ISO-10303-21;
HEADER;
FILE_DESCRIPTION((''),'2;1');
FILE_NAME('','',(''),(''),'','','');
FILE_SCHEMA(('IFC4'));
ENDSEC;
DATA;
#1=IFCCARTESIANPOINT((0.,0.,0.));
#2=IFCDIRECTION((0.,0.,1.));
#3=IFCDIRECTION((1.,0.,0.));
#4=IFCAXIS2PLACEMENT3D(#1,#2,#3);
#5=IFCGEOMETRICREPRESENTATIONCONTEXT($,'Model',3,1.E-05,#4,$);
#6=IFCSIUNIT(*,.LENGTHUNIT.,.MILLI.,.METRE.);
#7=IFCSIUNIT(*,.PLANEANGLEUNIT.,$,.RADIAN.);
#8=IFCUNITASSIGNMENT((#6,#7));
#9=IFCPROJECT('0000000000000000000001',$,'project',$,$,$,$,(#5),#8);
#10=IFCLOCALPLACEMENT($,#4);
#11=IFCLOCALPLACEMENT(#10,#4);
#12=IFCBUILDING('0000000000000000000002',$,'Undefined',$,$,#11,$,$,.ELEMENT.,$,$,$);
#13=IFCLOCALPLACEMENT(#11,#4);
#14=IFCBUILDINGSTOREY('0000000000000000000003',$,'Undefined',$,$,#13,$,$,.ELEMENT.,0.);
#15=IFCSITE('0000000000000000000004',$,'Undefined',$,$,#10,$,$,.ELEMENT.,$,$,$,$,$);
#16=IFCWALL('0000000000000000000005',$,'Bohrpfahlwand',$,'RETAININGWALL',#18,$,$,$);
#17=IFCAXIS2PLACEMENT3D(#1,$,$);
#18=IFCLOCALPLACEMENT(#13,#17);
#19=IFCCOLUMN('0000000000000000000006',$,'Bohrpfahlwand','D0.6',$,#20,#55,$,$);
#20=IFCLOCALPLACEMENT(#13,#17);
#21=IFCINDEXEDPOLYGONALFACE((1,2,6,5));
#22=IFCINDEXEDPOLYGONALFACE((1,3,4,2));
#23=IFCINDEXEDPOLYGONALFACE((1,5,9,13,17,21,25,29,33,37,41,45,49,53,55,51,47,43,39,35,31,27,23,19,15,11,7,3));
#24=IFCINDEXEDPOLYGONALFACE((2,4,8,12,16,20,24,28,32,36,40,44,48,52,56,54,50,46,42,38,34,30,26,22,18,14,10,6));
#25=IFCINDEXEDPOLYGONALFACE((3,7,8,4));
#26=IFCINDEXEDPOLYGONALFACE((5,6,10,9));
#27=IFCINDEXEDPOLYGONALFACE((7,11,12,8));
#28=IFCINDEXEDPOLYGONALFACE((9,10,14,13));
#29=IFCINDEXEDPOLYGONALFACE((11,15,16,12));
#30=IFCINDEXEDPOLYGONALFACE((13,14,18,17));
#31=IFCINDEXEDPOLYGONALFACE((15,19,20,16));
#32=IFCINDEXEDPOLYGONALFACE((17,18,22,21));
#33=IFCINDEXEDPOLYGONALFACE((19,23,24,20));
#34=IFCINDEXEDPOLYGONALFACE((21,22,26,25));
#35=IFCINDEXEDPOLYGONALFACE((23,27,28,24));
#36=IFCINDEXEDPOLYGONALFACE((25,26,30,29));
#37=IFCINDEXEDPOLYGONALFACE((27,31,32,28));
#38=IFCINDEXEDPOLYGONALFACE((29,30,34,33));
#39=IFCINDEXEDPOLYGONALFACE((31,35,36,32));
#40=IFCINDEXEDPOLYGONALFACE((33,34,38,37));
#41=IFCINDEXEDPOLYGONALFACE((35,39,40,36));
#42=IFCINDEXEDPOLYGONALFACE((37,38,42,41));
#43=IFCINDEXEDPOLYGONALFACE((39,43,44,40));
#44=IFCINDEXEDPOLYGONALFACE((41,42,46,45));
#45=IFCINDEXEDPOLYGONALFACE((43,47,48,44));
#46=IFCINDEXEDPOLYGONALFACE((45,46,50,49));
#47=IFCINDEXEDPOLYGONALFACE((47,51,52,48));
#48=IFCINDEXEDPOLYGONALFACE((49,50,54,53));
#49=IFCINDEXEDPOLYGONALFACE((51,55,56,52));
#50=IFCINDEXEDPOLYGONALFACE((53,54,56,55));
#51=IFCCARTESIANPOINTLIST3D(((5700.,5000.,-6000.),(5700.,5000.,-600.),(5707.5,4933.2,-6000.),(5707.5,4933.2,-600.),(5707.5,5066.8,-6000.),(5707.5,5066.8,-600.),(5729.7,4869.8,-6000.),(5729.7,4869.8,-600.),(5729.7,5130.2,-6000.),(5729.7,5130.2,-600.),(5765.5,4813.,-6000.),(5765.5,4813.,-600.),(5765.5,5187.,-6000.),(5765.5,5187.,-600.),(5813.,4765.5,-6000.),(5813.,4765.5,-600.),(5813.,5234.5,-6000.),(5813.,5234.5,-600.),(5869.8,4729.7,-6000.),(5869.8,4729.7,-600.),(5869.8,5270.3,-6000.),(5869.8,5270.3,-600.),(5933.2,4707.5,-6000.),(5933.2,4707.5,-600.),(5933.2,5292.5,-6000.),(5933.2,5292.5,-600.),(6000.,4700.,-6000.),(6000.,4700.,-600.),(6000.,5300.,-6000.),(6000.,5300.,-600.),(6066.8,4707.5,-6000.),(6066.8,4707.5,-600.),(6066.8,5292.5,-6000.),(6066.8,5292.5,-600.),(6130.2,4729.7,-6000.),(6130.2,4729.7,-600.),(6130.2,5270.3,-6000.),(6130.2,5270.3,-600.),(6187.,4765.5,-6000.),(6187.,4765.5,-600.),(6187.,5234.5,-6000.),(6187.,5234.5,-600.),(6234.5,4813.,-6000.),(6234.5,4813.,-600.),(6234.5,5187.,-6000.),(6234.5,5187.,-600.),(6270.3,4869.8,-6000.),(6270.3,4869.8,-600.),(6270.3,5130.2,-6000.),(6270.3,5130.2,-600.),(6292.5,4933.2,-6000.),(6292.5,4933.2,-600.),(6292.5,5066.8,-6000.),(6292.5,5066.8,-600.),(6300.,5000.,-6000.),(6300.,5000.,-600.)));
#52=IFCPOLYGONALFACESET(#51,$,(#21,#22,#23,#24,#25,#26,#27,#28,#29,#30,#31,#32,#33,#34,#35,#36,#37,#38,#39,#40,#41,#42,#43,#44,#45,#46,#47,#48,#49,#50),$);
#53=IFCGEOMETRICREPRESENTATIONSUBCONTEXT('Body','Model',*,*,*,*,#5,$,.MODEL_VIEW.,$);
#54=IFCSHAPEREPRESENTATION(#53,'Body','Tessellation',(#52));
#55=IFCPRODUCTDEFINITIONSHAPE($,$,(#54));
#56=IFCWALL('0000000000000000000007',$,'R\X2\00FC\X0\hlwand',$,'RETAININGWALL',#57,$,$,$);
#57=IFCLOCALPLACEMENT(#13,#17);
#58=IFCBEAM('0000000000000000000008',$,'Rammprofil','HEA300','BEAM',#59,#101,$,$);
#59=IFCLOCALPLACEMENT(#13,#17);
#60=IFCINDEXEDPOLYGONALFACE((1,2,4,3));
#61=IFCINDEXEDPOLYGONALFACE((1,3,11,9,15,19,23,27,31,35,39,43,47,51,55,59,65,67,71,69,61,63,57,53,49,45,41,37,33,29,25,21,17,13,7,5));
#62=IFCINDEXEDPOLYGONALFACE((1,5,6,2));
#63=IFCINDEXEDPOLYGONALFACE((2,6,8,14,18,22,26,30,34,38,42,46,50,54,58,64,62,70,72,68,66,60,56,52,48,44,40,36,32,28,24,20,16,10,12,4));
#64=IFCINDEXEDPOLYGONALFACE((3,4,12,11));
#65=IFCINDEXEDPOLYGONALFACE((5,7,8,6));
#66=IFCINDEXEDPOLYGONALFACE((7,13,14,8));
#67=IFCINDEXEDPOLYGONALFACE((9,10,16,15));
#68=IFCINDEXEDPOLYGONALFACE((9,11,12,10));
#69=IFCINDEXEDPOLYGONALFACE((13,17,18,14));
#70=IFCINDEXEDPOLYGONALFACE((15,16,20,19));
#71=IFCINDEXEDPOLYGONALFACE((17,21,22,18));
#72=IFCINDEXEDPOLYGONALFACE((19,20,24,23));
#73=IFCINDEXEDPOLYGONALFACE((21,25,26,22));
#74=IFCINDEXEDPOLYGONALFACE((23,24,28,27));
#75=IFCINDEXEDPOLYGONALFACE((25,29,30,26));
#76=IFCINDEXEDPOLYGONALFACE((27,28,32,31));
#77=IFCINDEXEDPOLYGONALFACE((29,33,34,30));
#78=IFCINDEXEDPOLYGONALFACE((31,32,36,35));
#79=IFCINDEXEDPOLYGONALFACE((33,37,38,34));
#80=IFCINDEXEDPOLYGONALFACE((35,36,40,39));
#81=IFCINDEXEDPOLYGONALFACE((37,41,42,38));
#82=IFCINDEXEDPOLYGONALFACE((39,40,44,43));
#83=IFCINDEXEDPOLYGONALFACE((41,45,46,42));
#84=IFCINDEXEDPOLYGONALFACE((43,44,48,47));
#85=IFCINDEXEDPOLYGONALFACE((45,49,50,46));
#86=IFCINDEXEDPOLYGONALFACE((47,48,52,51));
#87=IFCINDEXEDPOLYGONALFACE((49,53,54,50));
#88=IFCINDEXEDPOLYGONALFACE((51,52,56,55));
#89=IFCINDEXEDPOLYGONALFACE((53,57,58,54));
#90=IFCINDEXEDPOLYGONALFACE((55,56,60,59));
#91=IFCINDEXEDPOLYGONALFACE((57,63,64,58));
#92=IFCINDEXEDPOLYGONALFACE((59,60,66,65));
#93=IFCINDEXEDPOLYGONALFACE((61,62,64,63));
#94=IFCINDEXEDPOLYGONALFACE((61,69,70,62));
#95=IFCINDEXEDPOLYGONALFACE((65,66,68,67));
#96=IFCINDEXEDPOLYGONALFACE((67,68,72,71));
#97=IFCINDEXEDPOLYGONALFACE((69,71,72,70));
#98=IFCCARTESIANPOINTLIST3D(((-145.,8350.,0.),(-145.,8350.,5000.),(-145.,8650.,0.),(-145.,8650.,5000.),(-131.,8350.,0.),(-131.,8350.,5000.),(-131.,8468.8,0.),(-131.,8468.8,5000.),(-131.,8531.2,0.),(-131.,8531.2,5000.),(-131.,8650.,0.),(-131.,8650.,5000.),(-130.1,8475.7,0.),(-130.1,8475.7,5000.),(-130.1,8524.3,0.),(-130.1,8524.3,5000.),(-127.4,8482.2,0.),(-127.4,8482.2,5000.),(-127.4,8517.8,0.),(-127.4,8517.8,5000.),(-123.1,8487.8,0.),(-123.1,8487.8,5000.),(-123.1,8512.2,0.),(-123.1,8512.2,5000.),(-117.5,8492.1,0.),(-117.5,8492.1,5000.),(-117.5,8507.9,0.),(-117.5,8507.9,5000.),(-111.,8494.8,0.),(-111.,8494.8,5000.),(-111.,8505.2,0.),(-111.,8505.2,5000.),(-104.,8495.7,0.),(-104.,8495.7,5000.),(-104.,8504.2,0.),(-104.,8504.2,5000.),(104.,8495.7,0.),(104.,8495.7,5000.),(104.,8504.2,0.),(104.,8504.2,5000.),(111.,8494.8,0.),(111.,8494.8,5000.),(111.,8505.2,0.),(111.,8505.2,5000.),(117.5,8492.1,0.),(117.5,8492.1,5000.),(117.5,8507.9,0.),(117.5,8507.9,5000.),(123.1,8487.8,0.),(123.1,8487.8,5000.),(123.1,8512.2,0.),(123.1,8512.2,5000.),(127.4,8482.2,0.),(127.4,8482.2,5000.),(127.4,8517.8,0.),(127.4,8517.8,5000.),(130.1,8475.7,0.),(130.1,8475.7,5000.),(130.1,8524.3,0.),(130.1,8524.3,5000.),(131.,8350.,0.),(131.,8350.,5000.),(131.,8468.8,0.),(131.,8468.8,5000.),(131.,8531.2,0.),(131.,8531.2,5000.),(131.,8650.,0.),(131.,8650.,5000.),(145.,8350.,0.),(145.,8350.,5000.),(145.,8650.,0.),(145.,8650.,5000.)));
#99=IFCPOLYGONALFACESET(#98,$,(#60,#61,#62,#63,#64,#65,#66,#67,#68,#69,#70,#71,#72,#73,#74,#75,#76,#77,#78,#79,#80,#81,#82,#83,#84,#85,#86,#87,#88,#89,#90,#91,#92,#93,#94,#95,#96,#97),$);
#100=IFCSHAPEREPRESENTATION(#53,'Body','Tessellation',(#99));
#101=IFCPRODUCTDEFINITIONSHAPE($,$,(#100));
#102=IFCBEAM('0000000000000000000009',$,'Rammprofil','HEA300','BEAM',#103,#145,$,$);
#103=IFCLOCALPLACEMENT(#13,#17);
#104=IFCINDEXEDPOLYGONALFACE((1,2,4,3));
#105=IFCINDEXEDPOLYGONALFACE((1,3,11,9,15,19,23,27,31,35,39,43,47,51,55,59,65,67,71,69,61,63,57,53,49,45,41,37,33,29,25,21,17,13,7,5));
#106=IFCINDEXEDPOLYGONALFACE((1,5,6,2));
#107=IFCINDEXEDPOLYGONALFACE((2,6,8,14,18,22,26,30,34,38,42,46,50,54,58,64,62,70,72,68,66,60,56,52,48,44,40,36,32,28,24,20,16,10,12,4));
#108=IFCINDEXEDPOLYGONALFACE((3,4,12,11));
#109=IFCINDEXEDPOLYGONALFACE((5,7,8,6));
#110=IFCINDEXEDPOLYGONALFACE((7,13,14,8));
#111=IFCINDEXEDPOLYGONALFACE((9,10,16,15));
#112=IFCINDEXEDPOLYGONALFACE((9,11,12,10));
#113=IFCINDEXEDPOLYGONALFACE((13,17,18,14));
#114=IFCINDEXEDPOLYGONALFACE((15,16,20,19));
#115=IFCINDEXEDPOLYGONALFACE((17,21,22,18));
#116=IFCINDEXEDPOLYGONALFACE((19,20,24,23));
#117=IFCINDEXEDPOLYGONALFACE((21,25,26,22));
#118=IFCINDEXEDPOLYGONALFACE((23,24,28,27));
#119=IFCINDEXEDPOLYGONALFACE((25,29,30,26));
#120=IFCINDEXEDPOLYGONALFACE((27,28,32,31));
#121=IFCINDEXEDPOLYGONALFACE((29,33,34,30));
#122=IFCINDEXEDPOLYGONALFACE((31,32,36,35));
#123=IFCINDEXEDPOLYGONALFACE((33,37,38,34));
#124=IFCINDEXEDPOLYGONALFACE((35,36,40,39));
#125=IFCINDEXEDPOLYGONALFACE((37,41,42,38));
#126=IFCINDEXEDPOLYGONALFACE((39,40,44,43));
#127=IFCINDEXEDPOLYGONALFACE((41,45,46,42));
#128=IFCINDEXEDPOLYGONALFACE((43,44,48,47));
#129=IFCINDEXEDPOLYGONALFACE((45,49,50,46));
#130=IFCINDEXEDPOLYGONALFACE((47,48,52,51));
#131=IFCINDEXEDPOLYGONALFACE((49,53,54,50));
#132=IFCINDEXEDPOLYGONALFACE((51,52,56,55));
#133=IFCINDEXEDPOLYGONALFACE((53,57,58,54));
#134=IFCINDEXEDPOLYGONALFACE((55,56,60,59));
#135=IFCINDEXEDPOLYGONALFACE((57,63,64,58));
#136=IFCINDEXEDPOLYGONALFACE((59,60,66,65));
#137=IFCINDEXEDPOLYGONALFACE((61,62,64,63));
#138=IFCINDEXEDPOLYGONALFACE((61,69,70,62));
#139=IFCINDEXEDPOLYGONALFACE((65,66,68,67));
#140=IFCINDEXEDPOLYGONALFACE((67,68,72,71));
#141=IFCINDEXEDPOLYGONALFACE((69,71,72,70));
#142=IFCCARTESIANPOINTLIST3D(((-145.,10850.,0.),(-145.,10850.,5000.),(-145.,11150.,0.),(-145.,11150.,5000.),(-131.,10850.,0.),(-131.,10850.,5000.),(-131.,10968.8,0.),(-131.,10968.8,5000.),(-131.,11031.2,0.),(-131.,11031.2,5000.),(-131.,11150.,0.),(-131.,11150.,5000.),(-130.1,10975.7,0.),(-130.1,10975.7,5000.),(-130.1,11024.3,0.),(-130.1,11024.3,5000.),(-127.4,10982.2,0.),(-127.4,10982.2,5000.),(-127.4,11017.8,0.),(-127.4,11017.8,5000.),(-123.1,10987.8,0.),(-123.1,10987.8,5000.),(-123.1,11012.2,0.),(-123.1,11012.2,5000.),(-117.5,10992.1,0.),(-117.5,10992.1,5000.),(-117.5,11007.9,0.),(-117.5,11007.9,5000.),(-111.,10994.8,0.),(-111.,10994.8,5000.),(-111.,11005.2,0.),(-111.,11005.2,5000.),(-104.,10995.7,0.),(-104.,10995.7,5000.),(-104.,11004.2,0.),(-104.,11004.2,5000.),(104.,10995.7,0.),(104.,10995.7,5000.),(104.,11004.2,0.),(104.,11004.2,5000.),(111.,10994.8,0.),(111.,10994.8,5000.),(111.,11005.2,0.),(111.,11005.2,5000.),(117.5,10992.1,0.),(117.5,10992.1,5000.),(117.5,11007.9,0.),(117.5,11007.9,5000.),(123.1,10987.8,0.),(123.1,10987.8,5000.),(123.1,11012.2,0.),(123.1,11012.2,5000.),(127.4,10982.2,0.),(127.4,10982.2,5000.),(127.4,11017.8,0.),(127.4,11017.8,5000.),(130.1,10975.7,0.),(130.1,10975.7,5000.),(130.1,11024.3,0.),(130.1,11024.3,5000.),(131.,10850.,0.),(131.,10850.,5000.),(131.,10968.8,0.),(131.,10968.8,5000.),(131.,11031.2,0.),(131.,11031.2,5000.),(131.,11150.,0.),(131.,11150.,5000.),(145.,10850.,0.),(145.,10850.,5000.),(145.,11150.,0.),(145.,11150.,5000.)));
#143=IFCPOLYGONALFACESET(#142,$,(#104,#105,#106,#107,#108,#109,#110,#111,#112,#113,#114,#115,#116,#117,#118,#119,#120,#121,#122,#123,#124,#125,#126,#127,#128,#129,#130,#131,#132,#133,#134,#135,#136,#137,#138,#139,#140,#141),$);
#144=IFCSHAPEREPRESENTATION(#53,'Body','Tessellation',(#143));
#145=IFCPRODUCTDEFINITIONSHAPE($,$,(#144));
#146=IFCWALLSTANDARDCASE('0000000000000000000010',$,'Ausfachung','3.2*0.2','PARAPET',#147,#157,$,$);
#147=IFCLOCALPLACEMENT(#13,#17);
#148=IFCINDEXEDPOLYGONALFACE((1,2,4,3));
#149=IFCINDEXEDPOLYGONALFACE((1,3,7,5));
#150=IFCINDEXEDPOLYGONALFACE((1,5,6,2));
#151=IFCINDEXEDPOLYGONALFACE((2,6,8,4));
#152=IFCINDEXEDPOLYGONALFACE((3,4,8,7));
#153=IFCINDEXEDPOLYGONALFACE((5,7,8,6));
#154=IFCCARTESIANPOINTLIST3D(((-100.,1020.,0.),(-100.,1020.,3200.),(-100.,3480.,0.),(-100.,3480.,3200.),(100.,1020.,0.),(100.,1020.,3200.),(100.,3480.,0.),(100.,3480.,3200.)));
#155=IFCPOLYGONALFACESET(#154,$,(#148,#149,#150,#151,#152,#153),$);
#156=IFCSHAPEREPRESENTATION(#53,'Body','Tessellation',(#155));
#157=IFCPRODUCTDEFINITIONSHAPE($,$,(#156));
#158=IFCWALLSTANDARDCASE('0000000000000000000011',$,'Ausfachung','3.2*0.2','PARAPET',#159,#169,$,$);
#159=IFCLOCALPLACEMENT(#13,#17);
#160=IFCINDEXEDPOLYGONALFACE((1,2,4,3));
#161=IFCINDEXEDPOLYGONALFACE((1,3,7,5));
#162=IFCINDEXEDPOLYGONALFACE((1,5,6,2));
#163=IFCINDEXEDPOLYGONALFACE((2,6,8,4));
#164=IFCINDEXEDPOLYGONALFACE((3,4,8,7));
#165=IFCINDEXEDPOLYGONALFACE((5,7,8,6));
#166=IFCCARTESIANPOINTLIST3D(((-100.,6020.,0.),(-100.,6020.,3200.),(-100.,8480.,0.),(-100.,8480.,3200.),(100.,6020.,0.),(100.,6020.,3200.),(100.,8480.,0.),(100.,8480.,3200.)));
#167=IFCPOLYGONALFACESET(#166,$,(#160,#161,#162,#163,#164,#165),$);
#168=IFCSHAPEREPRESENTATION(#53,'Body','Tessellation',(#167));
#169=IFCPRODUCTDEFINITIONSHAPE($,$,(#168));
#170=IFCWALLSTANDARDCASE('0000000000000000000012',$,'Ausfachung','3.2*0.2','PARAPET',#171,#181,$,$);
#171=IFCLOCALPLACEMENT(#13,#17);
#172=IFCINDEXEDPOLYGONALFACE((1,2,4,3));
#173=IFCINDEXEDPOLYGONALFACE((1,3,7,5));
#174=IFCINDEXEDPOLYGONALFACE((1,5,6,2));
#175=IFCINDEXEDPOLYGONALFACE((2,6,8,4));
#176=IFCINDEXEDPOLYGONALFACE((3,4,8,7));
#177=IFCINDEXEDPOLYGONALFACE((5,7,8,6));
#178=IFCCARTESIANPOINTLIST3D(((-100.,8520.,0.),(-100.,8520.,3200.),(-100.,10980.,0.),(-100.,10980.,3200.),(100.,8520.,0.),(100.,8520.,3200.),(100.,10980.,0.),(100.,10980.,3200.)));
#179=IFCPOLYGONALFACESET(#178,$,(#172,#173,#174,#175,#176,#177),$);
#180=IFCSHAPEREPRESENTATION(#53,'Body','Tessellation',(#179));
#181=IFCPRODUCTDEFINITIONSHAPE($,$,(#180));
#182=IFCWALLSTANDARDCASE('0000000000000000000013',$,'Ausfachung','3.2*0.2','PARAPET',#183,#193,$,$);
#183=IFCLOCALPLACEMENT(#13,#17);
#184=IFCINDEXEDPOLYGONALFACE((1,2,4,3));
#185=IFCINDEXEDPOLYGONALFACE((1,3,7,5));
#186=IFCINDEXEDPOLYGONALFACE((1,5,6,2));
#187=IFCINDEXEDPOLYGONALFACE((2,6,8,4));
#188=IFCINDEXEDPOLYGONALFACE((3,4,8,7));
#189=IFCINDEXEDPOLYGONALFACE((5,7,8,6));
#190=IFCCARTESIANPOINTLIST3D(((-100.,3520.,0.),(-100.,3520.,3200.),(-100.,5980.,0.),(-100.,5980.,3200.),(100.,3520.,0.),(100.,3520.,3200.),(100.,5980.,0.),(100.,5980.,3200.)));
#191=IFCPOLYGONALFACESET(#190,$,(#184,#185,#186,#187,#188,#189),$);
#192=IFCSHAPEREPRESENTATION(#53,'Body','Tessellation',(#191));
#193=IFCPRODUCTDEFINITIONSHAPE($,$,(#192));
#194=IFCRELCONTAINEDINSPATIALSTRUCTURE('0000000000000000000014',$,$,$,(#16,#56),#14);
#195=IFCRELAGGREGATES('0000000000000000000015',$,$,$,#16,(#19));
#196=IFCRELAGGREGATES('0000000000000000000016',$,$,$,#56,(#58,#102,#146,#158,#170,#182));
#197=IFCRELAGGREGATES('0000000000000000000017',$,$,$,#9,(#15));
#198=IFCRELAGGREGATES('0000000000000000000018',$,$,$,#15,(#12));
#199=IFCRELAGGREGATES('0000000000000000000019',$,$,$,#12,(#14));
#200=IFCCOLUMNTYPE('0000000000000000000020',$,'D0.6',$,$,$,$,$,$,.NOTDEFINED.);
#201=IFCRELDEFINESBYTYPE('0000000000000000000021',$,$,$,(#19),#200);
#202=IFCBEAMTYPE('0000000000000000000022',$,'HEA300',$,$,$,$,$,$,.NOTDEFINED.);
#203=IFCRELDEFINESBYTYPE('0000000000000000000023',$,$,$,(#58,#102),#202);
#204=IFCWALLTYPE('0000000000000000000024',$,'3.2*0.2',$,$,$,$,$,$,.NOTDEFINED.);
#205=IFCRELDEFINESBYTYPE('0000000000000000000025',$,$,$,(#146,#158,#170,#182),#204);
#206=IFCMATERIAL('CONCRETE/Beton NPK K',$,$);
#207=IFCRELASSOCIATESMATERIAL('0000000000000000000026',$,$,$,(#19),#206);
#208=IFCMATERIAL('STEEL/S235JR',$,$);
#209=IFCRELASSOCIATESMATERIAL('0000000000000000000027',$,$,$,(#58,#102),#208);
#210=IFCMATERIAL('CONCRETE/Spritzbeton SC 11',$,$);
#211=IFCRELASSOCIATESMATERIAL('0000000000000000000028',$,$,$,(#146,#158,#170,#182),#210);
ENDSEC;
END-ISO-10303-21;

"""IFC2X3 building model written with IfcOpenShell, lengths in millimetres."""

from ifc_helpers import new_model, si_unit, frame, frame_2d, origin_with_axes, origin_2d_with_axis, place, context, subcontext, project, spatial, rectangle, circle, i_section, extrude, material, type_object, element, aggregate, save


model = new_model("IFC2X3")

# Units and contexts
model_context = context("Model", 3, precision=1e-05, world=origin_with_axes())
body_context = subcontext(model_context, "Body", "Model", "MODEL_VIEW")
ifc_project = project(units=[si_unit("LENGTHUNIT", "METRE", prefix="MILLI"), si_unit("PLANEANGLEUNIT", "RADIAN")], contexts=[model_context])

# Site, building, storey
site_placement = place(None, origin_with_axes())
site = spatial("IfcSite", under=ifc_project, at=site_placement, Name="Undefined", CompositionType="ELEMENT")
building_placement = place(site_placement, origin_with_axes())
building = spatial("IfcBuilding", under=site, at=building_placement, Name="Undefined", CompositionType="ELEMENT")
storey_placement = place(building_placement, origin_with_axes())
storey = spatial("IfcBuildingStorey", under=building, at=storey_placement, Name="Undefined", CompositionType="ELEMENT", Elevation=0.0)

# Shared definitions
ifc_material_1 = material(Name="CONCRETE/Beton NPK K")

# Wall, column
wall_1_placement = place(storey_placement, origin_with_axes())
wall_1 = element("IfcWall", 1, at=wall_1_placement, inside=storey, Name="Bohrpfahlwand", ObjectType="RETAININGWALL")
column_type = type_object("IfcColumnType", Name="D0.6", PredefinedType="NOTDEFINED")
column_1_placement = place(wall_1_placement, frame((6000.0, 5000.0, -6000.0), z_axis=(0.0, 0.0, 1.0), x_axis=(0.0, 1.0, 0.0)))
column_1 = element("IfcColumn", 2, at=column_1_placement, type_object=column_type, material=ifc_material_1, Name="Bohrpfahlwand", Description="D0.6", context=body_context, shape_type="SweptSolid", body=[
    extrude(circle(Radius=300.0, at=origin_2d_with_axis()), frame((0.0, 0.0, 5400.0), z_axis=(0.0, 0.0, -1.0), x_axis=(0.0, 1.0, 0.0)), (0.0, 0.0, 1.0), 5400.0),
])
aggregate(wall_1, [column_1])

# Walls, beams
wall_2_placement = place(storey_placement, origin_with_axes())
wall_2 = element("IfcWall", 3, at=wall_2_placement, inside=storey, Name="Rühlwand", ObjectType="RETAININGWALL")
ifc_material_2 = material(Name="STEEL/S235JR")
beam_type = type_object("IfcBeamType", Name="HEA300", PredefinedType="NOTDEFINED")
beam_1_placement = place(wall_2_placement, frame((0.0, 8500.0, 0.0), z_axis=(-1.0, 0.0, 0.0), x_axis=(0.0, 0.0, 1.0)))
beam_1 = element("IfcBeam", 4, at=beam_1_placement, type_object=beam_type, material=ifc_material_2, Name="Rammprofil", Description="HEA300", ObjectType="BEAM", context=body_context, shape_type="SweptSolid", body=[
    extrude(i_section(OverallWidth=300.0, OverallDepth=290.0, WebThickness=8.5, FlangeThickness=14.0, FilletRadius=27.0, at=origin_2d_with_axis()), frame((5000.0, 0.0, 0.0), z_axis=(-1.0, 0.0, 0.0), x_axis=(0.0, -1.0, 0.0)), (0.0, 0.0, 1.0), 5000.0),
])
beam_2_placement = place(wall_2_placement, frame((0.0, 11000.0, 0.0), z_axis=(-1.0, 0.0, 0.0), x_axis=(0.0, 0.0, 1.0)))
beam_2 = element("IfcBeam", 5, at=beam_2_placement, type_object=beam_type, material=ifc_material_2, Name="Rammprofil", Description="HEA300", ObjectType="BEAM", context=body_context, shape_type="SweptSolid", body=[
    extrude(i_section(OverallWidth=300.0, OverallDepth=290.0, WebThickness=8.5, FlangeThickness=14.0, FilletRadius=27.0, at=origin_2d_with_axis()), frame((5000.0, 0.0, 0.0), z_axis=(-1.0, 0.0, 0.0), x_axis=(0.0, -1.0, 0.0)), (0.0, 0.0, 1.0), 5000.0),
])
ifc_material_3 = material(Name="CONCRETE/Spritzbeton SC 11")
wall_type = type_object("IfcWallType", Name="3.2*0.2", PredefinedType="NOTDEFINED")
wall_3_placement = place(wall_2_placement, frame((0.0, 3480.0, 0.0), z_axis=(0.0, 0.0, 1.0), x_axis=(0.0, -1.0, 0.0)))
wall_3 = element("IfcWallStandardCase", 6, at=wall_3_placement, type_object=wall_type, material=ifc_material_3, Name="Ausfachung", Description="3.2*0.2", ObjectType="PARAPET", context=body_context, shape_type="SweptSolid", body=[
    extrude(rectangle(XDim=2460.0, YDim=200.0, at=frame_2d((0.0, 1230.0), x_axis=(0.0, -1.0))), frame((0.0, 0.0, 0.0), z_axis=(0.0, 0.0, 1.0), x_axis=(0.0, -1.0, 0.0)), (0.0, 0.0, 1.0), 3200.0),
])
wall_4_placement = place(wall_2_placement, frame((0.0, 8480.0, 0.0), z_axis=(0.0, 0.0, 1.0), x_axis=(0.0, -1.0, 0.0)))
wall_4 = element("IfcWallStandardCase", 7, at=wall_4_placement, type_object=wall_type, material=ifc_material_3, Name="Ausfachung", Description="3.2*0.2", ObjectType="PARAPET", context=body_context, shape_type="SweptSolid", body=[
    extrude(rectangle(XDim=2460.0, YDim=200.0, at=frame_2d((0.0, 1230.0), x_axis=(0.0, -1.0))), frame((0.0, 0.0, 0.0), z_axis=(0.0, 0.0, 1.0), x_axis=(0.0, -1.0, 0.0)), (0.0, 0.0, 1.0), 3200.0),
])
wall_5_placement = place(wall_2_placement, frame((0.0, 10980.0, 0.0), z_axis=(0.0, 0.0, 1.0), x_axis=(0.0, -1.0, 0.0)))
wall_5 = element("IfcWallStandardCase", 8, at=wall_5_placement, type_object=wall_type, material=ifc_material_3, Name="Ausfachung", Description="3.2*0.2", ObjectType="PARAPET", context=body_context, shape_type="SweptSolid", body=[
    extrude(rectangle(XDim=2460.0, YDim=200.0, at=frame_2d((0.0, 1230.0), x_axis=(0.0, -1.0))), frame((0.0, 0.0, 0.0), z_axis=(0.0, 0.0, 1.0), x_axis=(0.0, -1.0, 0.0)), (0.0, 0.0, 1.0), 3200.0),
])
wall_6_placement = place(wall_2_placement, frame((0.0, 5980.0, 0.0), z_axis=(0.0, 0.0, 1.0), x_axis=(0.0, -1.0, 0.0)))
wall_6 = element("IfcWallStandardCase", 9, at=wall_6_placement, type_object=wall_type, material=ifc_material_3, Name="Ausfachung", Description="3.2*0.2", ObjectType="PARAPET", context=body_context, shape_type="SweptSolid", body=[
    extrude(rectangle(XDim=2460.0, YDim=200.0, at=frame_2d((0.0, 1230.0), x_axis=(0.0, -1.0))), frame((0.0, 0.0, 0.0), z_axis=(0.0, 0.0, 1.0), x_axis=(0.0, -1.0, 0.0)), (0.0, 0.0, 1.0), 3200.0),
])
aggregate(wall_2, [beam_1, beam_2, wall_3, wall_4, wall_5, wall_6])

save(model, "model.ifc")
